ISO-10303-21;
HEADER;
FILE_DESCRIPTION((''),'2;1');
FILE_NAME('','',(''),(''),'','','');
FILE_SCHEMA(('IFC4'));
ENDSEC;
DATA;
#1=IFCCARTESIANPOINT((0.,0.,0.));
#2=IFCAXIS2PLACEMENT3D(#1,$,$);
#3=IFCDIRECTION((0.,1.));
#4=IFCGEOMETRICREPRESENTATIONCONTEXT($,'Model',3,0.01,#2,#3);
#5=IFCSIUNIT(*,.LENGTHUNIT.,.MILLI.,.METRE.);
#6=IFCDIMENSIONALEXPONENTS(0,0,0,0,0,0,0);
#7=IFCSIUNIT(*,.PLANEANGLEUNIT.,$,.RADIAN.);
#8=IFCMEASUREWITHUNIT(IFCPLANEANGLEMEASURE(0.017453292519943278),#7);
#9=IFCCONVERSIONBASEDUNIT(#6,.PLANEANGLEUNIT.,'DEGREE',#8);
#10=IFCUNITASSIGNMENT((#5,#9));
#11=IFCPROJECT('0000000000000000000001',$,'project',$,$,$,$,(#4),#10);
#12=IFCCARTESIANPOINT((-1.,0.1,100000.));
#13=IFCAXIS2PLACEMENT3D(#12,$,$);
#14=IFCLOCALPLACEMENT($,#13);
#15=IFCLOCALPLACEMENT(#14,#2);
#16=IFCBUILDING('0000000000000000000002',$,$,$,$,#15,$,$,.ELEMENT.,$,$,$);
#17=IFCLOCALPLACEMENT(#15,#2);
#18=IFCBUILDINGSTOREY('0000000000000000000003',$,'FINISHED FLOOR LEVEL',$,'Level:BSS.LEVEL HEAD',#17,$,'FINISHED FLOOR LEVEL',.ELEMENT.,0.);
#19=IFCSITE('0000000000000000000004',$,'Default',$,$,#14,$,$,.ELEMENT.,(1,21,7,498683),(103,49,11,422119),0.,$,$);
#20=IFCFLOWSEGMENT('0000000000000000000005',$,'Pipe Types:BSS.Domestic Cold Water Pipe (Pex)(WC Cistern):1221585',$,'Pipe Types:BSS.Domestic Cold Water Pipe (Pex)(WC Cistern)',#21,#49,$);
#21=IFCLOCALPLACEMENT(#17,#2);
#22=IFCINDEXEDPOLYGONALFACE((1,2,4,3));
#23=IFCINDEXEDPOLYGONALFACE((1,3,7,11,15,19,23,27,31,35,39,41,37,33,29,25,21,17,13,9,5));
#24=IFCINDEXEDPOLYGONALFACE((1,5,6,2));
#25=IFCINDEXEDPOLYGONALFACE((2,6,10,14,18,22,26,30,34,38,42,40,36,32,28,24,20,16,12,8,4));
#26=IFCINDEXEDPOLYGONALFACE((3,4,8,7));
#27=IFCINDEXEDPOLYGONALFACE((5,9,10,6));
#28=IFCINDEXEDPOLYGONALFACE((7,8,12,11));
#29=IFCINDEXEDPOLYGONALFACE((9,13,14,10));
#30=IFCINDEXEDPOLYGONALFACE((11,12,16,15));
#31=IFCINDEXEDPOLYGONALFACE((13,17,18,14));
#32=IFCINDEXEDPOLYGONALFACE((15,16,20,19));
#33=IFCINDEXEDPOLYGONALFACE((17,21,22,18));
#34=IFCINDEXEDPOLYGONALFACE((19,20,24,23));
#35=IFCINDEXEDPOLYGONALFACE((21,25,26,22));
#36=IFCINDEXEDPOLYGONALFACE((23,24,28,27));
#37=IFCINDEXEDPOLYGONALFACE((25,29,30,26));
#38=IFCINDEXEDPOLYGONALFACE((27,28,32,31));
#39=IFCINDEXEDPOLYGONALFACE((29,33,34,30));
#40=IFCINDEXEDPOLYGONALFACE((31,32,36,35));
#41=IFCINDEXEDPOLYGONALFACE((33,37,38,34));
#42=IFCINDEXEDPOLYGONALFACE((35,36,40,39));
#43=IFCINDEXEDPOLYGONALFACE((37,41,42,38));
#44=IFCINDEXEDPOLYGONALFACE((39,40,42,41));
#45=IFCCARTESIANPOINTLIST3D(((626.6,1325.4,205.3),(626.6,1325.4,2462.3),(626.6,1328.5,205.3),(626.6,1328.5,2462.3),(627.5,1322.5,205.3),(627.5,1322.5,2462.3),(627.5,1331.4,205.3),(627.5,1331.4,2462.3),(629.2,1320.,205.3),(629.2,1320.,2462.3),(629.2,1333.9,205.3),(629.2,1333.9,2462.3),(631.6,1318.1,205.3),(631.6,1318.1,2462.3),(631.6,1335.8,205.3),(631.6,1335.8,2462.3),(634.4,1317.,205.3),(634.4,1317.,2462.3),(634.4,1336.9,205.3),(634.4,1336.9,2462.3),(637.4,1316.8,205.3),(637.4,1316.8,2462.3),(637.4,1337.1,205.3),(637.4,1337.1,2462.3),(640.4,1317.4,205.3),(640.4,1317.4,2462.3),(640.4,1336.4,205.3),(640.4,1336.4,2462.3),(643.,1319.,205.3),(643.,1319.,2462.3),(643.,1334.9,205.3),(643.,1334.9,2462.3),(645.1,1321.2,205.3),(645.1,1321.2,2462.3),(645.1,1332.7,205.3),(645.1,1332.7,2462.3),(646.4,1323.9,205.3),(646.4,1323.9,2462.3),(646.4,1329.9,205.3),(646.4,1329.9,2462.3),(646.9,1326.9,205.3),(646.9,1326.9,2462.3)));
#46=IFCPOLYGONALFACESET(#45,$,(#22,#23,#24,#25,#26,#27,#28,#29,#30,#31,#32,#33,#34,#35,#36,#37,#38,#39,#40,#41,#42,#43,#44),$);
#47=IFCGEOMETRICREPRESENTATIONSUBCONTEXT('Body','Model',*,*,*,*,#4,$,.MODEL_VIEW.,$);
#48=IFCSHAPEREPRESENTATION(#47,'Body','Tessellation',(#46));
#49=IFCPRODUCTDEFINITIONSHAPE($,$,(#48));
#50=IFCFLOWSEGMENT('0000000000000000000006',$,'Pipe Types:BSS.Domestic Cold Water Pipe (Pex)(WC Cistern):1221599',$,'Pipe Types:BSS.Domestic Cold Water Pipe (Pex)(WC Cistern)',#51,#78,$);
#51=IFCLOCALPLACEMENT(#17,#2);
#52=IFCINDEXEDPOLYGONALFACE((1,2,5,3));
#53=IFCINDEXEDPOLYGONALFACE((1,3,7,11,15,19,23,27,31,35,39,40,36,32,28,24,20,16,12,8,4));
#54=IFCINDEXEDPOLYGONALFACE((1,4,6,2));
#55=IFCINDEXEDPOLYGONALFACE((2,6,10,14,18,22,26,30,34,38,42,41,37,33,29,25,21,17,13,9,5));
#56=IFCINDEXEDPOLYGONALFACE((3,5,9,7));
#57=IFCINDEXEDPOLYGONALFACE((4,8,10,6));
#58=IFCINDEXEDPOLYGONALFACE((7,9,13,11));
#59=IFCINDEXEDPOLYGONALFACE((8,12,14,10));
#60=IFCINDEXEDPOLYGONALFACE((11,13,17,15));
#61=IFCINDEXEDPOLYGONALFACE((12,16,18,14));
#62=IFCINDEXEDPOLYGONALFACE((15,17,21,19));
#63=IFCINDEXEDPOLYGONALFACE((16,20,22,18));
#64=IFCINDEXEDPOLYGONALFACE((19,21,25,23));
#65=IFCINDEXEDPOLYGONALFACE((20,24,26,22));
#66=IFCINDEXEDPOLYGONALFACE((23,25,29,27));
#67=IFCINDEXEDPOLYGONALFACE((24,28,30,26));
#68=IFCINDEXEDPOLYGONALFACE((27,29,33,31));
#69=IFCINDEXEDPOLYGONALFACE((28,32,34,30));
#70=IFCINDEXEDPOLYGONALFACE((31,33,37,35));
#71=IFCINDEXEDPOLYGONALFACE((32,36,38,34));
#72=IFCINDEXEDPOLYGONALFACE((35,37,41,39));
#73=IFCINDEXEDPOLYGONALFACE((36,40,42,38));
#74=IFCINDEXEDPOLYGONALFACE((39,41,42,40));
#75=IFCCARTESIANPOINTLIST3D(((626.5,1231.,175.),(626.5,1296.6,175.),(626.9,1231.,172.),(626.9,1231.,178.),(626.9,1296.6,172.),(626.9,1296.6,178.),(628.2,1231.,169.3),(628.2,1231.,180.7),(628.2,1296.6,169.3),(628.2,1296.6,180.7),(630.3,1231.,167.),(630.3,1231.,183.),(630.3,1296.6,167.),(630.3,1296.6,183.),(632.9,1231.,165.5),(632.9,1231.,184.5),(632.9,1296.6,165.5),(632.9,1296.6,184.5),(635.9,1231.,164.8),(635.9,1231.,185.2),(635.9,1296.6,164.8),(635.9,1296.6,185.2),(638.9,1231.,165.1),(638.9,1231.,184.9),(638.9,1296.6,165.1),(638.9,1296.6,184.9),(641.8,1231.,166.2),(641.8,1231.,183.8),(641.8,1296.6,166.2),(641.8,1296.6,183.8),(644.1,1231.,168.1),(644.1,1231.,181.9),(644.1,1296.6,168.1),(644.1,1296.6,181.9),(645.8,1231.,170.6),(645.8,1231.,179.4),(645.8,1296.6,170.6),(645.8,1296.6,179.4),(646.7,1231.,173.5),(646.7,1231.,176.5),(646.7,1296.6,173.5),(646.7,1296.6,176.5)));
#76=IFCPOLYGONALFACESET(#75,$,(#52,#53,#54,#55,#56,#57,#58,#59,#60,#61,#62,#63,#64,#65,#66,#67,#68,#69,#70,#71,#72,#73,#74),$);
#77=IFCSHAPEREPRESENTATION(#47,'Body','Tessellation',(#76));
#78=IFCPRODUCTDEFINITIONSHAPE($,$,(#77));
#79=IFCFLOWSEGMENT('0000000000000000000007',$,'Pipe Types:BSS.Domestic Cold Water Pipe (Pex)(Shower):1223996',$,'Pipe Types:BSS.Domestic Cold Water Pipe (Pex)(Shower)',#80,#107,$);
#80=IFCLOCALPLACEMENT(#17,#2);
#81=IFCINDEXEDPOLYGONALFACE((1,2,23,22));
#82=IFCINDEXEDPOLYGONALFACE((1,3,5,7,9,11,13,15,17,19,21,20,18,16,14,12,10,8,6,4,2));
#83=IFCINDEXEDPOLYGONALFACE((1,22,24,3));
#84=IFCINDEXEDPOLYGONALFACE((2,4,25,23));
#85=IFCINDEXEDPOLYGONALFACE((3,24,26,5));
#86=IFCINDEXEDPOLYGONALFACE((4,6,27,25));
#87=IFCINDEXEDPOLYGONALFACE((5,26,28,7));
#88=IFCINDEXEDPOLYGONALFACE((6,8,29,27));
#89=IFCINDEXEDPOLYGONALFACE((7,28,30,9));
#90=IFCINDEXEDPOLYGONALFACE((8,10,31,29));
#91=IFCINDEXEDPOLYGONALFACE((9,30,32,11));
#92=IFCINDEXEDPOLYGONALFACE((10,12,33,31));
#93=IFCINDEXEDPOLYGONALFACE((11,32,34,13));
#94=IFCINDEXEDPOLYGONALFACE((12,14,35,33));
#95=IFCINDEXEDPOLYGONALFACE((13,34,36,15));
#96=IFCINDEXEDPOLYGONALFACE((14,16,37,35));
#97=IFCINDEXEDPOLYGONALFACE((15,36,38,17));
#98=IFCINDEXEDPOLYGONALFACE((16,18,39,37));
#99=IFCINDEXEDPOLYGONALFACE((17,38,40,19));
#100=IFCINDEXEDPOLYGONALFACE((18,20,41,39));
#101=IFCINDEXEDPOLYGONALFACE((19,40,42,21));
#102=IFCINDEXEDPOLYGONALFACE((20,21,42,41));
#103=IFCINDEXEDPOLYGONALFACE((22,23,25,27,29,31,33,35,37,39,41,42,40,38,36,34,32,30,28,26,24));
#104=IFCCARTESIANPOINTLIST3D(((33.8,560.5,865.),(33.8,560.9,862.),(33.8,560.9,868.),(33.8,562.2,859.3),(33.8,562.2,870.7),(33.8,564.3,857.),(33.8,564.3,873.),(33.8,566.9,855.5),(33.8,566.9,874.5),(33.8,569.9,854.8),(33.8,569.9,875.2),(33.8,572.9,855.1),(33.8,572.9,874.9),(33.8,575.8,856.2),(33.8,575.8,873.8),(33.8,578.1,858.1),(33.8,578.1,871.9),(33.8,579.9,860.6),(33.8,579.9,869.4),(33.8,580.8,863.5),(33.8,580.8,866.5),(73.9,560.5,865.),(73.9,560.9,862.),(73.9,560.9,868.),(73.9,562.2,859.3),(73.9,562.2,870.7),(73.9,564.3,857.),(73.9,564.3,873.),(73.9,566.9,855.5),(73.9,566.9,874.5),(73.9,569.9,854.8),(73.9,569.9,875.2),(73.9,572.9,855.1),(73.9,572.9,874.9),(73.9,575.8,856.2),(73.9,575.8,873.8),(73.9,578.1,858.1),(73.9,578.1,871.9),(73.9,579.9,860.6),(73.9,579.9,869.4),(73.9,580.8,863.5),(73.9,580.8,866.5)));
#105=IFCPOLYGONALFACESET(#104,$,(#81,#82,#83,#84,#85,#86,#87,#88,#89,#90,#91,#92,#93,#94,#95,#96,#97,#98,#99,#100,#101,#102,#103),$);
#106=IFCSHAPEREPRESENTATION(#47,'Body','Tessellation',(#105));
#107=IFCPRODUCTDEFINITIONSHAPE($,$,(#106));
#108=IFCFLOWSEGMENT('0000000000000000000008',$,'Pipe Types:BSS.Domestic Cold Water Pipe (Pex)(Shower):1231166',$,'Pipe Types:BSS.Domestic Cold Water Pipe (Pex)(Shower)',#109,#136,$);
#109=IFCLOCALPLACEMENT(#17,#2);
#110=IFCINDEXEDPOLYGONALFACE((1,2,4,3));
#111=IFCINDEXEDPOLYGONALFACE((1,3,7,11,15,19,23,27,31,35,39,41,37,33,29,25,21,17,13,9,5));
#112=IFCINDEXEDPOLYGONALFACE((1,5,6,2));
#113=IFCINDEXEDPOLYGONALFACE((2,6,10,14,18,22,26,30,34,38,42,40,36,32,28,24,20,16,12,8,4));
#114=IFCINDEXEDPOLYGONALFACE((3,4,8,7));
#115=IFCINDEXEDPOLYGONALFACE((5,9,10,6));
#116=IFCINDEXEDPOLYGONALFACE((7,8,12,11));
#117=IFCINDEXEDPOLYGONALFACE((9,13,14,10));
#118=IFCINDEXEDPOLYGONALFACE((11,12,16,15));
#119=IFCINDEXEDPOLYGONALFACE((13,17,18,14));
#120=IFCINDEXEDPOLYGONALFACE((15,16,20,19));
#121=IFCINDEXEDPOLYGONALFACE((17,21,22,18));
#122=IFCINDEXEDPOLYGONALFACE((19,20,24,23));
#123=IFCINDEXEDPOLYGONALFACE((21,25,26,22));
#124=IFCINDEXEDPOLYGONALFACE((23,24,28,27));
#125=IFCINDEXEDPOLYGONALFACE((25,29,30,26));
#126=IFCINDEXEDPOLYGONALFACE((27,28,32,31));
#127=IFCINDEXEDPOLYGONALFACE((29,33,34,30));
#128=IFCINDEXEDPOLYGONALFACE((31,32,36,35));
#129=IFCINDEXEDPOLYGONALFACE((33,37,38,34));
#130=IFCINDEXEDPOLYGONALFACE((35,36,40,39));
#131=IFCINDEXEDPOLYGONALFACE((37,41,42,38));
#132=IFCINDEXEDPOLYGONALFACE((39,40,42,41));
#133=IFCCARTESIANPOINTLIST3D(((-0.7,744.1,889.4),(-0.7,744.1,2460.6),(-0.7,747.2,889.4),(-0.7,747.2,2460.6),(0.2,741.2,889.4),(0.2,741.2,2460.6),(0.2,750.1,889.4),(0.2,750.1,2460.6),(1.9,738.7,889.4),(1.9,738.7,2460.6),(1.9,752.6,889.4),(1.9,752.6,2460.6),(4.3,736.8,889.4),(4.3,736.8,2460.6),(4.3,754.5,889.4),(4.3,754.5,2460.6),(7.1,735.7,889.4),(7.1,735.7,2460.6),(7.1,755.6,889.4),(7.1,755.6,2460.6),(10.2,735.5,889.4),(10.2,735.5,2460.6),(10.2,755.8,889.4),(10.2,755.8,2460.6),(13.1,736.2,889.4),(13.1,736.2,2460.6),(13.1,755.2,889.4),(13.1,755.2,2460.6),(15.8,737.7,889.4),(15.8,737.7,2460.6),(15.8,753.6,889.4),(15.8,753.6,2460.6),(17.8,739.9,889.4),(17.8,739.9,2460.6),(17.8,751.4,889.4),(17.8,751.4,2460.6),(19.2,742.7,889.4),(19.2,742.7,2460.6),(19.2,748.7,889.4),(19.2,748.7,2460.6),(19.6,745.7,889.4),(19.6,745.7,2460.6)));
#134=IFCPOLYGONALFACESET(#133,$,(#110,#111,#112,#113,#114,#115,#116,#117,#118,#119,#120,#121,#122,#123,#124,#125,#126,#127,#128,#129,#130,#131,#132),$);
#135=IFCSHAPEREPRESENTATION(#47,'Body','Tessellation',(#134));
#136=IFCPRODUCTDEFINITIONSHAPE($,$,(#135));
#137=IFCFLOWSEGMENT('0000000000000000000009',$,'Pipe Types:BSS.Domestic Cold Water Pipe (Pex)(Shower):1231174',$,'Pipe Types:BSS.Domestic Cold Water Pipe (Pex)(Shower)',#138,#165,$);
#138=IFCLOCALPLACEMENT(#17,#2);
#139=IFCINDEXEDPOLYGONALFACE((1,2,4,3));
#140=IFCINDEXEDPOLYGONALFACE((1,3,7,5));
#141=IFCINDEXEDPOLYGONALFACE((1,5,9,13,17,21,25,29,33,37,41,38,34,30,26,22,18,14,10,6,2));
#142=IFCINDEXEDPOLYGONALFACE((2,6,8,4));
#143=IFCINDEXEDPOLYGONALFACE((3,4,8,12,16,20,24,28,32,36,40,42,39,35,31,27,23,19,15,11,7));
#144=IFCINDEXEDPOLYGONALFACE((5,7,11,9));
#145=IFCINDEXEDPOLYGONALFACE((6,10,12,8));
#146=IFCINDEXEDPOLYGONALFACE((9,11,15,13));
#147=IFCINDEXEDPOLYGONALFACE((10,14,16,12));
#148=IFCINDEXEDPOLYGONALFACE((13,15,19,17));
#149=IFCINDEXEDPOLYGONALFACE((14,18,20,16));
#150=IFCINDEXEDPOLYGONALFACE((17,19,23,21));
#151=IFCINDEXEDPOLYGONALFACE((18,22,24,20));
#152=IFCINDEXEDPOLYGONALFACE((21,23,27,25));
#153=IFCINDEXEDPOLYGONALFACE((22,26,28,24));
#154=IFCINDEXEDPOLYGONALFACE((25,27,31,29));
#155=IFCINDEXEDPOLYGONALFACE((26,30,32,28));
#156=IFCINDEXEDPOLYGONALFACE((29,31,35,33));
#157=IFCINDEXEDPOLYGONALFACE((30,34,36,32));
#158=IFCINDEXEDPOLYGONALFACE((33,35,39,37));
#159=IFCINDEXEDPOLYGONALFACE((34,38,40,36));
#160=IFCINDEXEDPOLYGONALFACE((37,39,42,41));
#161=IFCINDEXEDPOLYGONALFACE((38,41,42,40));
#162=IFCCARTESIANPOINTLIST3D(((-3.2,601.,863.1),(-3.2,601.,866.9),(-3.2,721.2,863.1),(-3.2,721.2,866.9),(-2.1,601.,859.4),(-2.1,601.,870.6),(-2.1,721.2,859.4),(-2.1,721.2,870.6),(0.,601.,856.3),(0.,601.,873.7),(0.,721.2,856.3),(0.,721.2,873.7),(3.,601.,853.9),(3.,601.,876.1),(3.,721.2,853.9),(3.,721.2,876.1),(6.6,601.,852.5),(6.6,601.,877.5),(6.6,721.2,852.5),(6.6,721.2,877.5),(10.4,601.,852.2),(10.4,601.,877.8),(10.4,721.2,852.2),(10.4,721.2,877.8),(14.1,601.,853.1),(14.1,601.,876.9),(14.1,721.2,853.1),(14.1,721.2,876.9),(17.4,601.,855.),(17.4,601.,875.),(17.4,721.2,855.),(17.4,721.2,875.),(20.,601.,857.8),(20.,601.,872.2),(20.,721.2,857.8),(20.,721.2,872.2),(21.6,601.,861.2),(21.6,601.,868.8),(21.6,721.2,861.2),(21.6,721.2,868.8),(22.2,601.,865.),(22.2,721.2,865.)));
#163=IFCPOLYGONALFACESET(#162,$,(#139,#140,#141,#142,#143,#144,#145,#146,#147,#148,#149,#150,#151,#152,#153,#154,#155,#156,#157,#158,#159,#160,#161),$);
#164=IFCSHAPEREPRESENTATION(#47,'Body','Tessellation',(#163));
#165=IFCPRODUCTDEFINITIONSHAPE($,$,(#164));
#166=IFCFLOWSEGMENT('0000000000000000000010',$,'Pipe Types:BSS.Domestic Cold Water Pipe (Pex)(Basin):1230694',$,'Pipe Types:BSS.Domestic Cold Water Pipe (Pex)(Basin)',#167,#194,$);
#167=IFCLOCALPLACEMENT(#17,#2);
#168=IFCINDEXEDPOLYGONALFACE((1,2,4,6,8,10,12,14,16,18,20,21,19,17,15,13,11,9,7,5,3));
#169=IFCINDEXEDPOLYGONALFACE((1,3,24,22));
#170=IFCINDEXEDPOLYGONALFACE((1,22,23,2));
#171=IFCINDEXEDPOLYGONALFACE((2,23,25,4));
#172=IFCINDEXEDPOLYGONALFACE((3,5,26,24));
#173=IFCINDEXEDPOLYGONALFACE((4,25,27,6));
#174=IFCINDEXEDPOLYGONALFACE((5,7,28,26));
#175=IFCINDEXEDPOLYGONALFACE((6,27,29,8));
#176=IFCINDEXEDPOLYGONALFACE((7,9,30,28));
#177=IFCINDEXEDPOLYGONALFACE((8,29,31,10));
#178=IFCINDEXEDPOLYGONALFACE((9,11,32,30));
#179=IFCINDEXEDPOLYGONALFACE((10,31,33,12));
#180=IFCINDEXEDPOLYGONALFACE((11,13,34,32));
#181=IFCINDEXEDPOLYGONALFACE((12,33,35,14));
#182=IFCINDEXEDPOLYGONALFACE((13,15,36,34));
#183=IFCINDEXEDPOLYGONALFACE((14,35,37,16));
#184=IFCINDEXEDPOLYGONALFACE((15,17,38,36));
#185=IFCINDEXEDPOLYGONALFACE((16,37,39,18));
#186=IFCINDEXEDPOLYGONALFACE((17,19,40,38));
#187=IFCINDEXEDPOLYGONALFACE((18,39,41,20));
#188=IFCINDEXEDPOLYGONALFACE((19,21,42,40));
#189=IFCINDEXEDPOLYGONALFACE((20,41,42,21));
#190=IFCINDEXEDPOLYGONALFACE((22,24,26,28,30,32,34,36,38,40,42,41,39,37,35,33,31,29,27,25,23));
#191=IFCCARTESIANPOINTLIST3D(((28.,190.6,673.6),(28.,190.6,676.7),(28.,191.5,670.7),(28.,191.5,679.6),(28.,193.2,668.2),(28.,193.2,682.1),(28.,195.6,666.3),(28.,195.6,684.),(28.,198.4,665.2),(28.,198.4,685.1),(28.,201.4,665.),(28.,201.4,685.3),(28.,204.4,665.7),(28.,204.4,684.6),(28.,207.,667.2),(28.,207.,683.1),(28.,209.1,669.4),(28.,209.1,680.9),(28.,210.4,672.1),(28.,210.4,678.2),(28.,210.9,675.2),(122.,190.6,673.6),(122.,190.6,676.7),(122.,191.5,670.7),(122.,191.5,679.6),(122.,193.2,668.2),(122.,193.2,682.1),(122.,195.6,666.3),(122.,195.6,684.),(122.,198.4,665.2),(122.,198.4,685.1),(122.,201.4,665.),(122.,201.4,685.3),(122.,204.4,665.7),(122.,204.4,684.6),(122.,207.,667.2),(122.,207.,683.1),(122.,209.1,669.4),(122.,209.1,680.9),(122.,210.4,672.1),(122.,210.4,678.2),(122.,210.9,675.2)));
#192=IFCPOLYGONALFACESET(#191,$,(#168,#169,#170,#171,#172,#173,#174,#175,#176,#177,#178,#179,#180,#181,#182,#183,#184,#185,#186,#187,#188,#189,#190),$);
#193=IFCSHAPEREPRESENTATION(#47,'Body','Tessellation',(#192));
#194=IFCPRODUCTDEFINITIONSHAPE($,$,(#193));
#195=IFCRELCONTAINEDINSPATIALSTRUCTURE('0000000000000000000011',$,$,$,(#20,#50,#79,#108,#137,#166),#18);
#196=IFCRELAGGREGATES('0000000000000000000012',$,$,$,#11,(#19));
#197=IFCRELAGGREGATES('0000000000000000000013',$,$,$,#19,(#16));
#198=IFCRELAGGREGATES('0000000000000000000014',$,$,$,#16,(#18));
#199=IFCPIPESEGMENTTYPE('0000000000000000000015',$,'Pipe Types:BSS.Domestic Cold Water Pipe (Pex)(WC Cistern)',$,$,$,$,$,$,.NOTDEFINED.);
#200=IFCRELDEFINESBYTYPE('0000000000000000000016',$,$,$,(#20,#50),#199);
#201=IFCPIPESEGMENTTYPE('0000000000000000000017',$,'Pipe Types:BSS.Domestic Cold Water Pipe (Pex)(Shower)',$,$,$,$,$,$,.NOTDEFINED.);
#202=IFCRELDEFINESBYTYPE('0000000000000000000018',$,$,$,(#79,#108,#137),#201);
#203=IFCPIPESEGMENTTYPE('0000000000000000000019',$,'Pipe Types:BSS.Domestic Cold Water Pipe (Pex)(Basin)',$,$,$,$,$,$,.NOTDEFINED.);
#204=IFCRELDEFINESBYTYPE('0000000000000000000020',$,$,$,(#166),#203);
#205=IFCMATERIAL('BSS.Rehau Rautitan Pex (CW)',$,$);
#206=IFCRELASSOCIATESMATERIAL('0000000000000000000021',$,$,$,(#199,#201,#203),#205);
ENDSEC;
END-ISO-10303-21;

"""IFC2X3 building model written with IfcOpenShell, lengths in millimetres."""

from ifc_helpers import new_model, entity, si_unit, converted_unit, direction, frame, frame_2d, origin, origin_2d_with_axis, place, context, subcontext, project, spatial, circle, extrude, material, type_object, element, save


model = new_model("IFC2X3")

# Units and contexts
model_context = context("Model", 3, precision=0.01, world=origin(), true_north=direction((0.0, 1.0)))
body_context = subcontext(model_context, "Body", "Model", "MODEL_VIEW")
ifc_project = project(units=[si_unit("LENGTHUNIT", "METRE", prefix="MILLI"), converted_unit("PLANEANGLEUNIT", "DEGREE", entity("IfcPlaneAngleMeasure", 0.017453292519943278), si_unit("PLANEANGLEUNIT", "RADIAN"), dimensions=[0, 0, 0, 0, 0, 0, 0])], contexts=[model_context])

# Site, building, storey
site_placement = place(None, frame((-1.0, 0.1, 100000.0)))
site = spatial("IfcSite", under=ifc_project, at=site_placement, Name="Default", CompositionType="ELEMENT", RefLatitude=(1, 21, 7, 498683), RefLongitude=(103, 49, 11, 422119), RefElevation=0.0)
building_placement = place(site_placement, origin())
building = spatial("IfcBuilding", under=site, at=building_placement, CompositionType="ELEMENT")
storey_placement = place(building_placement, origin())
storey = spatial("IfcBuildingStorey", under=building, at=storey_placement, Name="FINISHED FLOOR LEVEL", ObjectType="Level:BSS.LEVEL HEAD", LongName="FINISHED FLOOR LEVEL", CompositionType="ELEMENT", Elevation=0.0)

# Flow segments
ifc_material_1 = material(Name="BSS.Rehau Rautitan Pex (CW)")
pipe_segment_type_1 = type_object("IfcPipeSegmentType", Name="Pipe Types:BSS.Domestic Cold Water Pipe (Pex)(WC Cistern)", PredefinedType="NOTDEFINED", material=ifc_material_1)
flow_segment_1_placement = place(storey_placement, origin())
element("IfcFlowSegment", 1, at=flow_segment_1_placement, inside=storey, type_object=pipe_segment_type_1, Name="Pipe Types:BSS.Domestic Cold Water Pipe (Pex)(WC Cistern):1221585", ObjectType="Pipe Types:BSS.Domestic Cold Water Pipe (Pex)(WC Cistern)", context=body_context, shape_type="SweptSolid", body=[
    extrude(circle(Radius=10.2, at=frame_2d((0.0, 0.0), x_axis=(1.0, 0.0))), frame((636.7, 1326.9, 205.3)), (0.0, 0.0, 1.0), 2257.0),
])
flow_segment_2_placement = place(storey_placement, origin())
element("IfcFlowSegment", 2, at=flow_segment_2_placement, inside=storey, type_object=pipe_segment_type_1, Name="Pipe Types:BSS.Domestic Cold Water Pipe (Pex)(WC Cistern):1221599", ObjectType="Pipe Types:BSS.Domestic Cold Water Pipe (Pex)(WC Cistern)", context=body_context, shape_type="SweptSolid", body=[
    extrude(circle(Radius=10.2, at=frame_2d((0.0, 0.0), x_axis=(1.0, 0.0))), frame((636.7, 1231.0, 175.0), z_axis=(0.0, 1.0, 0.0), x_axis=(-1.0, 0.0, 0.0)), (0.0, 0.0, 1.0), 65.6),
])
pipe_segment_type_2 = type_object("IfcPipeSegmentType", Name="Pipe Types:BSS.Domestic Cold Water Pipe (Pex)(Shower)", PredefinedType="NOTDEFINED", material=ifc_material_1)
flow_segment_3_placement = place(storey_placement, origin())
element("IfcFlowSegment", 3, at=flow_segment_3_placement, inside=storey, type_object=pipe_segment_type_2, Name="Pipe Types:BSS.Domestic Cold Water Pipe (Pex)(Shower):1223996", ObjectType="Pipe Types:BSS.Domestic Cold Water Pipe (Pex)(Shower)", context=body_context, shape_type="SweptSolid", body=[
    extrude(circle(Radius=10.2, at=frame_2d((0.0, 0.0), x_axis=(1.0, 0.0))), frame((33.8, 570.7, 865.0), z_axis=(1.0, 0.0, 0.0), x_axis=(0.0, -1.0, 0.0)), (0.0, 0.0, 1.0), 40.0),
])
flow_segment_4_placement = place(storey_placement, origin())
element("IfcFlowSegment", 4, at=flow_segment_4_placement, inside=storey, type_object=pipe_segment_type_2, Name="Pipe Types:BSS.Domestic Cold Water Pipe (Pex)(Shower):1231166", ObjectType="Pipe Types:BSS.Domestic Cold Water Pipe (Pex)(Shower)", context=body_context, shape_type="SweptSolid", body=[
    extrude(circle(Radius=10.2, at=frame_2d((0.0, 0.0), x_axis=(1.0, 0.0))), frame((9.4, 745.7, 889.4)), (0.0, 0.0, 1.0), 1571.1),
])
flow_segment_5_placement = place(storey_placement, origin())
element("IfcFlowSegment", 5, at=flow_segment_5_placement, inside=storey, type_object=pipe_segment_type_2, Name="Pipe Types:BSS.Domestic Cold Water Pipe (Pex)(Shower):1231174", ObjectType="Pipe Types:BSS.Domestic Cold Water Pipe (Pex)(Shower)", context=body_context, shape_type="SweptSolid", body=[
    extrude(circle(Radius=12.8, at=frame_2d((0.0, 0.0), x_axis=(1.0, 0.0))), frame((9.4, 601.0, 865.0), z_axis=(0.0, 1.0, 0.0), x_axis=(1.0, 0.0, 0.0)), (0.0, 0.0, 1.0), 120.2),
])
pipe_segment_type_3 = type_object("IfcPipeSegmentType", Name="Pipe Types:BSS.Domestic Cold Water Pipe (Pex)(Basin)", PredefinedType="NOTDEFINED", material=ifc_material_1)
flow_segment_6_placement = place(storey_placement, origin())
element("IfcFlowSegment", 6, at=flow_segment_6_placement, inside=storey, type_object=pipe_segment_type_3, Name="Pipe Types:BSS.Domestic Cold Water Pipe (Pex)(Basin):1230694", ObjectType="Pipe Types:BSS.Domestic Cold Water Pipe (Pex)(Basin)", context=body_context, shape_type="SweptSolid", body=[
    extrude(circle(Radius=10.2, at=origin_2d_with_axis()), frame((28.0, 200.7, 675.2), z_axis=(1.0, 0.0, 0.0), x_axis=(0.0, 1.0, 0.0)), (0.0, 0.0, 1.0), 94.0),
])

save(model, "model.ifc")
